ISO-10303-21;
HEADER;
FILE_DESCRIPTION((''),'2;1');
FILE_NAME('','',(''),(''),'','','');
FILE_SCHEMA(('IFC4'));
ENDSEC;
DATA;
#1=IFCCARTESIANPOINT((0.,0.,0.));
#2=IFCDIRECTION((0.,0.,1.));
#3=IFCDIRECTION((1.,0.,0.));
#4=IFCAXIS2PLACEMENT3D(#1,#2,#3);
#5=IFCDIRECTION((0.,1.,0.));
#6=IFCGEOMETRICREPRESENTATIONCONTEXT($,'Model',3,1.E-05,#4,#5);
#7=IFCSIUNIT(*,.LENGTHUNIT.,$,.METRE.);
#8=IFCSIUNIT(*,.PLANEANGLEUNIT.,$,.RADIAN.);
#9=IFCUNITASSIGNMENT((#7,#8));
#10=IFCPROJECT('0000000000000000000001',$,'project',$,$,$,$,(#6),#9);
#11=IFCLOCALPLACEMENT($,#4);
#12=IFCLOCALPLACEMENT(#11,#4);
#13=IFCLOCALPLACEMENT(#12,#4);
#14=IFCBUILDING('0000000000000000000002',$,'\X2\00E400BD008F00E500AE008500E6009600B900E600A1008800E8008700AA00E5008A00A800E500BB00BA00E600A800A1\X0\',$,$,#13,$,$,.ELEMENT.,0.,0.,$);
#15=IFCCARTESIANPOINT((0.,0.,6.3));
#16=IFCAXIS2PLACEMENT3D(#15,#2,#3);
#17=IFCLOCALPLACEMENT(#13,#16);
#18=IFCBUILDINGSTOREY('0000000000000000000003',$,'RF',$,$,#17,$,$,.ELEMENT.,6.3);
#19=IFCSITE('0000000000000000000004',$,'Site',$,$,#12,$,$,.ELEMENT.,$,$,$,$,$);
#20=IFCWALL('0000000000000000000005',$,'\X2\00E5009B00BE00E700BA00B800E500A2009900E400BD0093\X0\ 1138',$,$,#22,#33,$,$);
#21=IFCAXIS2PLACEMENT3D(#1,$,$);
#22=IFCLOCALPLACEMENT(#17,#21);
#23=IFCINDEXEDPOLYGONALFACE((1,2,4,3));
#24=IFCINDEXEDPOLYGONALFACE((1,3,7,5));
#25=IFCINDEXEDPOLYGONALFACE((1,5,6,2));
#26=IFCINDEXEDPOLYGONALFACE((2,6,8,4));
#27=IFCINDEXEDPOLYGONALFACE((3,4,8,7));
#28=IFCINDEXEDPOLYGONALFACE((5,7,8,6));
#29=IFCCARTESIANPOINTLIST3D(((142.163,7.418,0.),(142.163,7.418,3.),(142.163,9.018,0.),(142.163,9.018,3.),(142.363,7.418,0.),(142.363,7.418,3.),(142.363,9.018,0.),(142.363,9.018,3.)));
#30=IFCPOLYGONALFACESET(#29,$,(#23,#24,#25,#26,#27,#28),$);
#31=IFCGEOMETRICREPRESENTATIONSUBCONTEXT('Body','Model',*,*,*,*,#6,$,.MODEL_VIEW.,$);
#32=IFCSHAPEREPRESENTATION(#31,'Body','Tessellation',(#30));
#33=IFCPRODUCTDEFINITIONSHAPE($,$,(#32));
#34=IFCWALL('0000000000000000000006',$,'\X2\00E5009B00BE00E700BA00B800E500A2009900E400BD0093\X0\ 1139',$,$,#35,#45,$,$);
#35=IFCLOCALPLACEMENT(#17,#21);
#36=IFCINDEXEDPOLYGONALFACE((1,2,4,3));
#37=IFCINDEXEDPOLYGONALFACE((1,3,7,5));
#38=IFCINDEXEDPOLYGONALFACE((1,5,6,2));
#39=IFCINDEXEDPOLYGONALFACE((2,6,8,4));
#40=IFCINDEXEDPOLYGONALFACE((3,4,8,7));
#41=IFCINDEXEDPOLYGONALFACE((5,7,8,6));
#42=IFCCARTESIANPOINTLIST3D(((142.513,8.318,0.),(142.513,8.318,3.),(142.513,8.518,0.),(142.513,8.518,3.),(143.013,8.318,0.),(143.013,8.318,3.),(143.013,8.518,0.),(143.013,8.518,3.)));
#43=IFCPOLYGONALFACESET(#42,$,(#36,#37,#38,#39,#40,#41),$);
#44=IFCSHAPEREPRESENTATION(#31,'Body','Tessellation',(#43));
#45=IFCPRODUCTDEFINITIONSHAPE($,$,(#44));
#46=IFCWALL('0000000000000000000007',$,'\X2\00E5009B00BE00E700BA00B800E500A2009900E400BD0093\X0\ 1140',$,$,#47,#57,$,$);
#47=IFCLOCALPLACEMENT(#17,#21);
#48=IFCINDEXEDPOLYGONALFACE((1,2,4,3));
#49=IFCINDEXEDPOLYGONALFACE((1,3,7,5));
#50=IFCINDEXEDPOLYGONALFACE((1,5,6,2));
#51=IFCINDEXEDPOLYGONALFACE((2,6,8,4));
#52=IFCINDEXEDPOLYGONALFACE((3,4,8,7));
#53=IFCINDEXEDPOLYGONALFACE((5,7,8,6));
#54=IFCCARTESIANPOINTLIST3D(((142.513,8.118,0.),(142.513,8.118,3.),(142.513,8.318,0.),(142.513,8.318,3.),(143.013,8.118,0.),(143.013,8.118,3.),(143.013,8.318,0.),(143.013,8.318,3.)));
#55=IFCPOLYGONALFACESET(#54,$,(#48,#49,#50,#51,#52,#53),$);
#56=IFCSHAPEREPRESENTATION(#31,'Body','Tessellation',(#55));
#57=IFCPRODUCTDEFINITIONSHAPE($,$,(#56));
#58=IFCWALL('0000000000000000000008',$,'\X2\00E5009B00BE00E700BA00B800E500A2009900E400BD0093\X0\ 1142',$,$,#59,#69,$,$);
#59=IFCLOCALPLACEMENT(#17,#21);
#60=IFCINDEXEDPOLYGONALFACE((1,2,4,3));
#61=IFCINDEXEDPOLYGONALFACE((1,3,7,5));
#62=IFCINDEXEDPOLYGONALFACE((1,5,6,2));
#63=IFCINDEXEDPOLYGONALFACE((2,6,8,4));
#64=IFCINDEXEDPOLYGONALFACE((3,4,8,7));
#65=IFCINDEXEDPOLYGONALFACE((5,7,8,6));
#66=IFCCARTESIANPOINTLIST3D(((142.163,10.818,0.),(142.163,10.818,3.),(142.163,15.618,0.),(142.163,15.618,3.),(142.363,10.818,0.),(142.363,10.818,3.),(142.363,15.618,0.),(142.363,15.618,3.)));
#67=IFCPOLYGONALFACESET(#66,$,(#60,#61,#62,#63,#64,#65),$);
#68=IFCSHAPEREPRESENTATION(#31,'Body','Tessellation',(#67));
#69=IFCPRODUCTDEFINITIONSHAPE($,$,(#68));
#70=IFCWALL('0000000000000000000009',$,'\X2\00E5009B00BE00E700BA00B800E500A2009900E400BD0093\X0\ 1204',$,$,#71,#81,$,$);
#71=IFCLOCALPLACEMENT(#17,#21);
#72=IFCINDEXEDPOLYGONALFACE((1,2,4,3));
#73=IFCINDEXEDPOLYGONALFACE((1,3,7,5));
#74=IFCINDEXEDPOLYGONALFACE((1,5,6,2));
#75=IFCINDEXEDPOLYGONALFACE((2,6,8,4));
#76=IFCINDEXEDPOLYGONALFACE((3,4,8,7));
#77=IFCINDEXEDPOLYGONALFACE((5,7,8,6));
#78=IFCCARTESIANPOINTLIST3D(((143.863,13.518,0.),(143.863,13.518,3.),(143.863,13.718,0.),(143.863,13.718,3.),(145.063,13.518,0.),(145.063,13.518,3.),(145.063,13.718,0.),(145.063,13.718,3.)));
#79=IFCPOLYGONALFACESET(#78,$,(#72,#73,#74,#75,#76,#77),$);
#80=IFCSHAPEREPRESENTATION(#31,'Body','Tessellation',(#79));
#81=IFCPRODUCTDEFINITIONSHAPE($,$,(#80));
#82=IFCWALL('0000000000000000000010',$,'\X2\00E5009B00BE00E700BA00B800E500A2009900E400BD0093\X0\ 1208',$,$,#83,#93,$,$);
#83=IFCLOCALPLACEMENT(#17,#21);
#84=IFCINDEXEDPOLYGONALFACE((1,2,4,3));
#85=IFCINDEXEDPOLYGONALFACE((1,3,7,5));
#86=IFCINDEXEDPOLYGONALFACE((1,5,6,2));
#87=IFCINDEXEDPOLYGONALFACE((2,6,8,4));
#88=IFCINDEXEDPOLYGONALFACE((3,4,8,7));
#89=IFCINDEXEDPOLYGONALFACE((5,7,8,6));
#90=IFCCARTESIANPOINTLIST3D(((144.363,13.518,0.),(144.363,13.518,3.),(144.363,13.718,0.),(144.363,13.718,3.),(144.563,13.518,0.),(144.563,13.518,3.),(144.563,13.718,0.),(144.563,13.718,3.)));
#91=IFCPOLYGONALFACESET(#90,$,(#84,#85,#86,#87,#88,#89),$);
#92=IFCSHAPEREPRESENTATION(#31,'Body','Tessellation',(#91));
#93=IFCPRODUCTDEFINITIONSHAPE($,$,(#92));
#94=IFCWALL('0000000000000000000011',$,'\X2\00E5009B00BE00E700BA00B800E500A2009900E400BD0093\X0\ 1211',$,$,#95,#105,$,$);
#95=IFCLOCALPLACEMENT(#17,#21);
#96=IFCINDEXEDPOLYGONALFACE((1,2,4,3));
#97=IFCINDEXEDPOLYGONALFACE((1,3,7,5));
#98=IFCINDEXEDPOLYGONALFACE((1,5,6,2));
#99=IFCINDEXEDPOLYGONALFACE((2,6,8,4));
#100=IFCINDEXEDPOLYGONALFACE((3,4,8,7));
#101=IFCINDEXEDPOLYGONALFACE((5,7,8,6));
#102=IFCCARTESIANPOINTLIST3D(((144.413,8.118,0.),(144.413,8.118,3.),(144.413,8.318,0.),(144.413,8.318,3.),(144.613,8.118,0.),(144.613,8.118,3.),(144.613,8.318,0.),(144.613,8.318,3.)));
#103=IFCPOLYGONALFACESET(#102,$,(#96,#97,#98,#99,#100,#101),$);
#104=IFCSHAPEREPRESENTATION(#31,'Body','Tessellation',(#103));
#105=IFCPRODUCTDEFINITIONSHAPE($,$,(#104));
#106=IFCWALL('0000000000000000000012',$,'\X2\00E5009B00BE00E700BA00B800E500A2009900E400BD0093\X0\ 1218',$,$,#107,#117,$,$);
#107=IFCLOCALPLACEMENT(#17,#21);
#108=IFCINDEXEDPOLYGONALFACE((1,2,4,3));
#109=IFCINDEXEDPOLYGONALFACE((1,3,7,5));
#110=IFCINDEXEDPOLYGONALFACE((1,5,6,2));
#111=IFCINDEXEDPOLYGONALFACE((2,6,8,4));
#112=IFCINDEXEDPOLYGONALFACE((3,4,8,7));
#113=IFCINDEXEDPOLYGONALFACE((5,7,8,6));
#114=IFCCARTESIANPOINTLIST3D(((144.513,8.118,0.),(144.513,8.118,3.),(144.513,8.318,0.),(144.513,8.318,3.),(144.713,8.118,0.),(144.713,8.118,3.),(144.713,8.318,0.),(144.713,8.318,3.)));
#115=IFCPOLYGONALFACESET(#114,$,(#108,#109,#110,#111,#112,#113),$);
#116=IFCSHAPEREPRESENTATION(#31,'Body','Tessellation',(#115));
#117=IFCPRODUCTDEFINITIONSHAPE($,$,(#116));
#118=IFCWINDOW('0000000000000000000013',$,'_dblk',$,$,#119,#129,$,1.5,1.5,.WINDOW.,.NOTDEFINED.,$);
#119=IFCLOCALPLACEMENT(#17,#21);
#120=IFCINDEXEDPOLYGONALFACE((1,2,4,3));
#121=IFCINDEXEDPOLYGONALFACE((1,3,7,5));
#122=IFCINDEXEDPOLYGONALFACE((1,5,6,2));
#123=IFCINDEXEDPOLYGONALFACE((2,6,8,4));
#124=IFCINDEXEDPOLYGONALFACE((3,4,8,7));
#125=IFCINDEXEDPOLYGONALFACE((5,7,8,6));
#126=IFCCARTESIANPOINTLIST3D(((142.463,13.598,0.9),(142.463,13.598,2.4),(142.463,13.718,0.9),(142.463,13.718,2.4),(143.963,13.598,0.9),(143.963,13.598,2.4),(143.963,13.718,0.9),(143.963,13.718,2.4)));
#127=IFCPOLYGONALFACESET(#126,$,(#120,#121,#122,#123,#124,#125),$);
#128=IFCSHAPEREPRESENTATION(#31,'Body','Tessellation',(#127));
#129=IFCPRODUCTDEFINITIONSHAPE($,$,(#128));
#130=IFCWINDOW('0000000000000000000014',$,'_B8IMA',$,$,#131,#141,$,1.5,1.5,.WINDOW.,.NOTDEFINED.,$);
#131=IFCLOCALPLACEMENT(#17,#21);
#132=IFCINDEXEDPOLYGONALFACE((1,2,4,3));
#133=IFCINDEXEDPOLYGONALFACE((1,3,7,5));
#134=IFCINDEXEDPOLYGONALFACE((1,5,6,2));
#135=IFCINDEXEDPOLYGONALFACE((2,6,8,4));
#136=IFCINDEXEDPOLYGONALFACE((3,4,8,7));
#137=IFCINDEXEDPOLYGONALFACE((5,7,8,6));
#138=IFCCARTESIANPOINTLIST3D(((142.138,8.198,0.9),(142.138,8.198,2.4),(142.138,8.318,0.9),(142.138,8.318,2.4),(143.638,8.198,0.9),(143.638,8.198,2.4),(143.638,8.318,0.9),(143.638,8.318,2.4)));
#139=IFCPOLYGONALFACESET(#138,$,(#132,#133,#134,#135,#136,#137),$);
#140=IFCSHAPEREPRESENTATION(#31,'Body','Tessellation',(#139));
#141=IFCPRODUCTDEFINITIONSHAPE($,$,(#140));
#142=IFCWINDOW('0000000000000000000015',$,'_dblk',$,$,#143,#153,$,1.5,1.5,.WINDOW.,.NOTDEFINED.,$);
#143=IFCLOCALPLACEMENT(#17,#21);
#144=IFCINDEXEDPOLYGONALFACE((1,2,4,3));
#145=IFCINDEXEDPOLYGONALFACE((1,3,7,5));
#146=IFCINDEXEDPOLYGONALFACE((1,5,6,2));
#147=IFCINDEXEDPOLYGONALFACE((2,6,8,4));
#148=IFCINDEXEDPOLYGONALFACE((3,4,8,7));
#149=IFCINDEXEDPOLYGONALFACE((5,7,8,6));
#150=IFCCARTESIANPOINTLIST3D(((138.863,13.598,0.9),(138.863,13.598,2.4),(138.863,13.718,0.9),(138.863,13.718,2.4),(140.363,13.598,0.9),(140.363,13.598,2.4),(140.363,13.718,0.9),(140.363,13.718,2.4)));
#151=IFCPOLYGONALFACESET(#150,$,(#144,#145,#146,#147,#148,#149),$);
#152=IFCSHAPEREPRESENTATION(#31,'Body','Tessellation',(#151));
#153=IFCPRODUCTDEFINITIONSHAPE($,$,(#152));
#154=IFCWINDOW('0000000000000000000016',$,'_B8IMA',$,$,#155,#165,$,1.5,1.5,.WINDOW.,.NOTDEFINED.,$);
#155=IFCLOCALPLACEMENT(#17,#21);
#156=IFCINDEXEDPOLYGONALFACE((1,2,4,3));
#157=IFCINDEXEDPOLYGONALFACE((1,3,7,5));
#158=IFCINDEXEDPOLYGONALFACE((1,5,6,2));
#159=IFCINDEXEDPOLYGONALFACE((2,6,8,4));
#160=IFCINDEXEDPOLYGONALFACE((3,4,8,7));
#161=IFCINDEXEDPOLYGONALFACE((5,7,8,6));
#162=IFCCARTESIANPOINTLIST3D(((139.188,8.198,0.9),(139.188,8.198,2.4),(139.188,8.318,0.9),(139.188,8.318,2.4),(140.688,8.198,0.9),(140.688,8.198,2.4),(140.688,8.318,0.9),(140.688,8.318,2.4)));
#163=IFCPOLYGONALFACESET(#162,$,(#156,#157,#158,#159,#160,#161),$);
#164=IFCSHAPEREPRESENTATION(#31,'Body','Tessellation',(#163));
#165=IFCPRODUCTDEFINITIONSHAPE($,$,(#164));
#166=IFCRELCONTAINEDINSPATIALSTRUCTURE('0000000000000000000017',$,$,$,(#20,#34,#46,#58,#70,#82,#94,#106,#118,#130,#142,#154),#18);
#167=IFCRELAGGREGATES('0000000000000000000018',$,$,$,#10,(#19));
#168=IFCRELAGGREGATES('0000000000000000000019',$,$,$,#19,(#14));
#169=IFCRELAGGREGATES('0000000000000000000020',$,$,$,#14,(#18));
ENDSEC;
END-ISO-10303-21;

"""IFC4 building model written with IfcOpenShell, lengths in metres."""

from ifc_helpers import new_model, si_unit, direction, frame, frame_2d, origin_with_axes, place, context, subcontext, project, spatial, rectangle, extrude, element, save


model = new_model("IFC4")

# Units and contexts
model_context = context("Model", 3, precision=1e-05, world=origin_with_axes(), true_north=direction((0.0, 1.0, 0.0)))
body_context = subcontext(model_context, "Body", "Model", "MODEL_VIEW")
ifc_project = project(units=[si_unit("LENGTHUNIT", "METRE"), si_unit("PLANEANGLEUNIT", "RADIAN")], contexts=[model_context])

# Site, building, storey
placement = place(None, origin_with_axes())
site_placement = place(placement, origin_with_axes())
site = spatial("IfcSite", under=ifc_project, at=site_placement, Name="Site", CompositionType="ELEMENT")
building_placement = place(site_placement, origin_with_axes())
building = spatial("IfcBuilding", under=site, at=building_placement, Name="ä½\u008få®\u0085æ\u0096¹æ¡\u0088è\u0087ªå\u008a¨å»ºæ¨¡", CompositionType="ELEMENT", ElevationOfRefHeight=0.0, ElevationOfTerrain=0.0)
storey_placement = place(building_placement, frame((0.0, 0.0, 6.3), z_axis=(0.0, 0.0, 1.0), x_axis=(1.0, 0.0, 0.0)))
storey = spatial("IfcBuildingStorey", under=building, at=storey_placement, Name="RF", CompositionType="ELEMENT", Elevation=6.3)

# Walls
wall_1_placement = place(storey_placement, frame((142.263, 8.218, 0.0), z_axis=(0.0, 0.0, 1.0), x_axis=(0.0, -1.0, 0.0)))
element("IfcWall", 1, at=wall_1_placement, inside=storey, Name="å\u009b¾çº¸å¢\u0099ä½\u0093 1138", context=body_context, shape_type="SweptSolid", body=[
    extrude(rectangle(XDim=1.6, YDim=0.2, at=frame_2d((0.0, 0.0), x_axis=(1.0, 0.0, 0.0))), frame((0.0, 0.0, 0.0), z_axis=(0.0, 0.0, 1.0)), (0.0, 0.0, 1.0), 3.0),
])
for number, where, z_axis, x_axis, name in (
    (2, (142.763, 8.418, 0.0), (0.0, 0.0, 1.0), (-1.0, 0.0, 0.0), "å\u009b¾çº¸å¢\u0099ä½\u0093 1139"),
    (3, (142.763, 8.218, 0.0), (0.0, 0.0, 1.0), (-1.0, 0.0, 0.0), "å\u009b¾çº¸å¢\u0099ä½\u0093 1140"),
):
    element("IfcWall", number, at=place(storey_placement, frame(where, z_axis=z_axis, x_axis=x_axis)), inside=storey, Name=name, context=body_context, shape_type="SweptSolid", body=[
        extrude(rectangle(XDim=0.5, YDim=0.2, at=frame_2d((0.0, 0.0), x_axis=(1.0, 0.0, 0.0))), frame((0.0, 0.0, 0.0), z_axis=(0.0, 0.0, 1.0)), (0.0, 0.0, 1.0), 3.0),
    ])
wall_2_placement = place(storey_placement, frame((142.263, 13.218, 0.0), z_axis=(0.0, 0.0, 1.0), x_axis=(0.0, -1.0, 0.0)))
element("IfcWall", 4, at=wall_2_placement, inside=storey, Name="å\u009b¾çº¸å¢\u0099ä½\u0093 1142", context=body_context, shape_type="SweptSolid", body=[
    extrude(rectangle(XDim=4.8, YDim=0.2, at=frame_2d((0.0, 0.0), x_axis=(1.0, 0.0, 0.0))), frame((0.0, 0.0, 0.0), z_axis=(0.0, 0.0, 1.0)), (0.0, 0.0, 1.0), 3.0),
])
wall_3_placement = place(storey_placement, frame((144.463, 13.618, 0.0), z_axis=(0.0, 0.0, 1.0), x_axis=(1.0, 0.0, 0.0)))
element("IfcWall", 5, at=wall_3_placement, inside=storey, Name="å\u009b¾çº¸å¢\u0099ä½\u0093 1204", context=body_context, shape_type="SweptSolid", body=[
    extrude(rectangle(XDim=1.2, YDim=0.2, at=frame_2d((0.0, 0.0), x_axis=(1.0, 0.0, 0.0))), frame((0.0, 0.0, 0.0), z_axis=(0.0, 0.0, 1.0)), (0.0, 0.0, 1.0), 3.0),
])
for number, where, z_axis, x_axis, name in (
    (6, (144.463, 13.618, 0.0), (0.0, 0.0, 1.0), (0.0, 1.0, 0.0), "å\u009b¾çº¸å¢\u0099ä½\u0093 1208"),
    (7, (144.513, 8.218, 0.0), (0.0, 0.0, 1.0), (0.0, 1.0, 0.0), "å\u009b¾çº¸å¢\u0099ä½\u0093 1211"),
    (8, (144.613, 8.218, 0.0), (0.0, 0.0, 1.0), (0.0, -1.0, 0.0), "å\u009b¾çº¸å¢\u0099ä½\u0093 1218"),
):
    element("IfcWall", number, at=place(storey_placement, frame(where, z_axis=z_axis, x_axis=x_axis)), inside=storey, Name=name, context=body_context, shape_type="SweptSolid", body=[
        extrude(rectangle(XDim=0.2, YDim=0.2, at=frame_2d((0.0, 0.0), x_axis=(1.0, 0.0, 0.0))), frame((0.0, 0.0, 0.0), z_axis=(0.0, 0.0, 1.0)), (0.0, 0.0, 1.0), 3.0),
    ])

# Windows
for number, where, z_axis, x_axis, name in (
    (9, (143.213, 13.658, 0.9), (0.0, 0.0, 1.0), (1.0, 0.0, 0.0), "_dblk"),
    (10, (142.888, 8.258, 0.9), (0.0, 0.0, 1.0), (1.0, 0.0, 0.0), "_B8IMA"),
    (11, (139.613, 13.658, 0.9), (0.0, 0.0, 1.0), (1.0, 0.0, 0.0), "_dblk"),
    (12, (139.938, 8.258, 0.9), (0.0, 0.0, 1.0), (1.0, 0.0, 0.0), "_B8IMA"),
):
    element("IfcWindow", number, at=place(storey_placement, frame(where, z_axis=z_axis, x_axis=x_axis)), inside=storey, Name=name, OverallHeight=1.5, OverallWidth=1.5, PartitioningType="NOTDEFINED", PredefinedType="WINDOW", context=body_context, shape_type="SweptSolid", body=[
        extrude(rectangle(XDim=1.5, YDim=0.12, at=frame_2d((0.0, 0.0), x_axis=(1.0, 0.0, 0.0))), frame((0.0, 0.0, 0.0), z_axis=(0.0, 0.0, 1.0)), (0.0, 0.0, 1.0), 1.5),
    ])

save(model, "model.ifc")
